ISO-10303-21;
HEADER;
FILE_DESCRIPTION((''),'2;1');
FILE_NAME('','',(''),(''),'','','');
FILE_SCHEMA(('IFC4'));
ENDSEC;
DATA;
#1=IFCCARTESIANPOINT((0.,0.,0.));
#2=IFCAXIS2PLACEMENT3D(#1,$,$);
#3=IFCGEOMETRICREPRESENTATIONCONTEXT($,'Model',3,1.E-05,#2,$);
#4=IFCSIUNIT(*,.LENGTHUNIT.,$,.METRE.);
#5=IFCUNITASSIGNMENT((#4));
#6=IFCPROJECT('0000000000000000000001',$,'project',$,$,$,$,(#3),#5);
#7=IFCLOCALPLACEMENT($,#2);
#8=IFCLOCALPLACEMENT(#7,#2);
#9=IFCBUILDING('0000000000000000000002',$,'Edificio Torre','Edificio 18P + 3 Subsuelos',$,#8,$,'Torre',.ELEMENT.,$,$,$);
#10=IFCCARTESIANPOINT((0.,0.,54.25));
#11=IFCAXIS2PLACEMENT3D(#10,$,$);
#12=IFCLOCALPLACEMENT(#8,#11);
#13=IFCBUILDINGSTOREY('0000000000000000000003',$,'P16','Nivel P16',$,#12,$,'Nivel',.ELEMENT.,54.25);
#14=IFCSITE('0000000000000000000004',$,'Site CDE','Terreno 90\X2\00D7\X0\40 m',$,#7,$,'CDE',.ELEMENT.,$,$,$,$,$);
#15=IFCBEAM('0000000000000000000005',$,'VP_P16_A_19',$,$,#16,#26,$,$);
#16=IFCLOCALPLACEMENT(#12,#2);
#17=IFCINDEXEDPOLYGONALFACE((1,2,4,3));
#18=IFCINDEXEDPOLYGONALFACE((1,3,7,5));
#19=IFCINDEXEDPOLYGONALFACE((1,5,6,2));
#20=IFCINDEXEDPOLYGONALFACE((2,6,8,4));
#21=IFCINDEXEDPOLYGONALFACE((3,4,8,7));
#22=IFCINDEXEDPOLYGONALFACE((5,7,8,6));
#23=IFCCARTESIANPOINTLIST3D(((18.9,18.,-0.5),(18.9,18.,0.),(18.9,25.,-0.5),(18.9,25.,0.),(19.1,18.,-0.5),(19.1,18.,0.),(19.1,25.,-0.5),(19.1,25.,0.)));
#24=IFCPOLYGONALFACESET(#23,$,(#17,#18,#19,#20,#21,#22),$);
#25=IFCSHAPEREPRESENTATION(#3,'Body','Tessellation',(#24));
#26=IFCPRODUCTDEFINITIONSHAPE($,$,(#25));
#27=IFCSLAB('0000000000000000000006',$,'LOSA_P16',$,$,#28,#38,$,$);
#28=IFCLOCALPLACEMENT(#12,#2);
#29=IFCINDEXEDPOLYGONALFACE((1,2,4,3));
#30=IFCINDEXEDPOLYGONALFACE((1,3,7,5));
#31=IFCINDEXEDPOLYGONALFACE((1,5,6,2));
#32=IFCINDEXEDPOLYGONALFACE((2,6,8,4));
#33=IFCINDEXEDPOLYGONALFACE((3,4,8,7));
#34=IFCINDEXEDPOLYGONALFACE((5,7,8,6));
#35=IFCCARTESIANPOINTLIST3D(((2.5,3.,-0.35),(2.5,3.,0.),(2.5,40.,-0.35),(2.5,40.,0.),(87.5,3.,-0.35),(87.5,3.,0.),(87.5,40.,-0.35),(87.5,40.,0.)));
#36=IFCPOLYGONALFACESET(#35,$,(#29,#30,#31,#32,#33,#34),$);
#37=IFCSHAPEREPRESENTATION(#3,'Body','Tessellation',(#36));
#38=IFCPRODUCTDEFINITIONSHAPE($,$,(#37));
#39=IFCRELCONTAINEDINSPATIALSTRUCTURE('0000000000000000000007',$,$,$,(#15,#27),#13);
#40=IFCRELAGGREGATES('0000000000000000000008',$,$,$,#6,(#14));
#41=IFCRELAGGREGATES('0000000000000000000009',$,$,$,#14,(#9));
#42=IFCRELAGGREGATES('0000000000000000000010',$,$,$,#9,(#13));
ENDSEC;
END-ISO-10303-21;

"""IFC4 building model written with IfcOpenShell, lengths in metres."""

from ifc_helpers import new_model, si_unit, frame, origin, origin_2d, place, context, project, spatial, rectangle, extrude, element, save


model = new_model("IFC4")

# Units and contexts
model_context = context("Model", 3, precision=1e-05, world=origin())
ifc_project = project(units=[si_unit("LENGTHUNIT", "METRE")], contexts=[model_context])

# Site, building, storey
site_placement = place(None, origin())
site = spatial("IfcSite", under=ifc_project, at=site_placement, Name="Site CDE", Description="Terreno 90×40 m", LongName="CDE", CompositionType="ELEMENT")
building_placement = place(site_placement, origin())
building = spatial("IfcBuilding", under=site, at=building_placement, Name="Edificio Torre", Description="Edificio 18P + 3 Subsuelos", LongName="Torre", CompositionType="ELEMENT")
storey_placement = place(building_placement, frame((0.0, 0.0, 54.25)))
storey = spatial("IfcBuildingStorey", under=building, at=storey_placement, Name="P16", Description="Nivel P16", LongName="Nivel", CompositionType="ELEMENT", Elevation=54.25)

# Beam
beam_1_placement = place(storey_placement, frame((19.0, 21.5, -0.5)))
element("IfcBeam", 1, at=beam_1_placement, inside=storey, Name="VP_P16_A_19", context=model_context, shape_type="SweptSolid", body=[
    extrude(rectangle(XDim=0.2, YDim=7.0, at=origin_2d()), origin(), (0.0, 0.0, 1.0), 0.5),
])

# Slab
slab_placement = place(storey_placement, frame((45.0, 21.5, -0.35)))
element("IfcSlab", 2, at=slab_placement, inside=storey, Name="LOSA_P16", context=model_context, shape_type="SweptSolid", body=[
    extrude(rectangle(XDim=85.0, YDim=37.0, at=origin_2d()), origin(), (0.0, 0.0, 1.0), 0.35),
])

save(model, "model.ifc")
